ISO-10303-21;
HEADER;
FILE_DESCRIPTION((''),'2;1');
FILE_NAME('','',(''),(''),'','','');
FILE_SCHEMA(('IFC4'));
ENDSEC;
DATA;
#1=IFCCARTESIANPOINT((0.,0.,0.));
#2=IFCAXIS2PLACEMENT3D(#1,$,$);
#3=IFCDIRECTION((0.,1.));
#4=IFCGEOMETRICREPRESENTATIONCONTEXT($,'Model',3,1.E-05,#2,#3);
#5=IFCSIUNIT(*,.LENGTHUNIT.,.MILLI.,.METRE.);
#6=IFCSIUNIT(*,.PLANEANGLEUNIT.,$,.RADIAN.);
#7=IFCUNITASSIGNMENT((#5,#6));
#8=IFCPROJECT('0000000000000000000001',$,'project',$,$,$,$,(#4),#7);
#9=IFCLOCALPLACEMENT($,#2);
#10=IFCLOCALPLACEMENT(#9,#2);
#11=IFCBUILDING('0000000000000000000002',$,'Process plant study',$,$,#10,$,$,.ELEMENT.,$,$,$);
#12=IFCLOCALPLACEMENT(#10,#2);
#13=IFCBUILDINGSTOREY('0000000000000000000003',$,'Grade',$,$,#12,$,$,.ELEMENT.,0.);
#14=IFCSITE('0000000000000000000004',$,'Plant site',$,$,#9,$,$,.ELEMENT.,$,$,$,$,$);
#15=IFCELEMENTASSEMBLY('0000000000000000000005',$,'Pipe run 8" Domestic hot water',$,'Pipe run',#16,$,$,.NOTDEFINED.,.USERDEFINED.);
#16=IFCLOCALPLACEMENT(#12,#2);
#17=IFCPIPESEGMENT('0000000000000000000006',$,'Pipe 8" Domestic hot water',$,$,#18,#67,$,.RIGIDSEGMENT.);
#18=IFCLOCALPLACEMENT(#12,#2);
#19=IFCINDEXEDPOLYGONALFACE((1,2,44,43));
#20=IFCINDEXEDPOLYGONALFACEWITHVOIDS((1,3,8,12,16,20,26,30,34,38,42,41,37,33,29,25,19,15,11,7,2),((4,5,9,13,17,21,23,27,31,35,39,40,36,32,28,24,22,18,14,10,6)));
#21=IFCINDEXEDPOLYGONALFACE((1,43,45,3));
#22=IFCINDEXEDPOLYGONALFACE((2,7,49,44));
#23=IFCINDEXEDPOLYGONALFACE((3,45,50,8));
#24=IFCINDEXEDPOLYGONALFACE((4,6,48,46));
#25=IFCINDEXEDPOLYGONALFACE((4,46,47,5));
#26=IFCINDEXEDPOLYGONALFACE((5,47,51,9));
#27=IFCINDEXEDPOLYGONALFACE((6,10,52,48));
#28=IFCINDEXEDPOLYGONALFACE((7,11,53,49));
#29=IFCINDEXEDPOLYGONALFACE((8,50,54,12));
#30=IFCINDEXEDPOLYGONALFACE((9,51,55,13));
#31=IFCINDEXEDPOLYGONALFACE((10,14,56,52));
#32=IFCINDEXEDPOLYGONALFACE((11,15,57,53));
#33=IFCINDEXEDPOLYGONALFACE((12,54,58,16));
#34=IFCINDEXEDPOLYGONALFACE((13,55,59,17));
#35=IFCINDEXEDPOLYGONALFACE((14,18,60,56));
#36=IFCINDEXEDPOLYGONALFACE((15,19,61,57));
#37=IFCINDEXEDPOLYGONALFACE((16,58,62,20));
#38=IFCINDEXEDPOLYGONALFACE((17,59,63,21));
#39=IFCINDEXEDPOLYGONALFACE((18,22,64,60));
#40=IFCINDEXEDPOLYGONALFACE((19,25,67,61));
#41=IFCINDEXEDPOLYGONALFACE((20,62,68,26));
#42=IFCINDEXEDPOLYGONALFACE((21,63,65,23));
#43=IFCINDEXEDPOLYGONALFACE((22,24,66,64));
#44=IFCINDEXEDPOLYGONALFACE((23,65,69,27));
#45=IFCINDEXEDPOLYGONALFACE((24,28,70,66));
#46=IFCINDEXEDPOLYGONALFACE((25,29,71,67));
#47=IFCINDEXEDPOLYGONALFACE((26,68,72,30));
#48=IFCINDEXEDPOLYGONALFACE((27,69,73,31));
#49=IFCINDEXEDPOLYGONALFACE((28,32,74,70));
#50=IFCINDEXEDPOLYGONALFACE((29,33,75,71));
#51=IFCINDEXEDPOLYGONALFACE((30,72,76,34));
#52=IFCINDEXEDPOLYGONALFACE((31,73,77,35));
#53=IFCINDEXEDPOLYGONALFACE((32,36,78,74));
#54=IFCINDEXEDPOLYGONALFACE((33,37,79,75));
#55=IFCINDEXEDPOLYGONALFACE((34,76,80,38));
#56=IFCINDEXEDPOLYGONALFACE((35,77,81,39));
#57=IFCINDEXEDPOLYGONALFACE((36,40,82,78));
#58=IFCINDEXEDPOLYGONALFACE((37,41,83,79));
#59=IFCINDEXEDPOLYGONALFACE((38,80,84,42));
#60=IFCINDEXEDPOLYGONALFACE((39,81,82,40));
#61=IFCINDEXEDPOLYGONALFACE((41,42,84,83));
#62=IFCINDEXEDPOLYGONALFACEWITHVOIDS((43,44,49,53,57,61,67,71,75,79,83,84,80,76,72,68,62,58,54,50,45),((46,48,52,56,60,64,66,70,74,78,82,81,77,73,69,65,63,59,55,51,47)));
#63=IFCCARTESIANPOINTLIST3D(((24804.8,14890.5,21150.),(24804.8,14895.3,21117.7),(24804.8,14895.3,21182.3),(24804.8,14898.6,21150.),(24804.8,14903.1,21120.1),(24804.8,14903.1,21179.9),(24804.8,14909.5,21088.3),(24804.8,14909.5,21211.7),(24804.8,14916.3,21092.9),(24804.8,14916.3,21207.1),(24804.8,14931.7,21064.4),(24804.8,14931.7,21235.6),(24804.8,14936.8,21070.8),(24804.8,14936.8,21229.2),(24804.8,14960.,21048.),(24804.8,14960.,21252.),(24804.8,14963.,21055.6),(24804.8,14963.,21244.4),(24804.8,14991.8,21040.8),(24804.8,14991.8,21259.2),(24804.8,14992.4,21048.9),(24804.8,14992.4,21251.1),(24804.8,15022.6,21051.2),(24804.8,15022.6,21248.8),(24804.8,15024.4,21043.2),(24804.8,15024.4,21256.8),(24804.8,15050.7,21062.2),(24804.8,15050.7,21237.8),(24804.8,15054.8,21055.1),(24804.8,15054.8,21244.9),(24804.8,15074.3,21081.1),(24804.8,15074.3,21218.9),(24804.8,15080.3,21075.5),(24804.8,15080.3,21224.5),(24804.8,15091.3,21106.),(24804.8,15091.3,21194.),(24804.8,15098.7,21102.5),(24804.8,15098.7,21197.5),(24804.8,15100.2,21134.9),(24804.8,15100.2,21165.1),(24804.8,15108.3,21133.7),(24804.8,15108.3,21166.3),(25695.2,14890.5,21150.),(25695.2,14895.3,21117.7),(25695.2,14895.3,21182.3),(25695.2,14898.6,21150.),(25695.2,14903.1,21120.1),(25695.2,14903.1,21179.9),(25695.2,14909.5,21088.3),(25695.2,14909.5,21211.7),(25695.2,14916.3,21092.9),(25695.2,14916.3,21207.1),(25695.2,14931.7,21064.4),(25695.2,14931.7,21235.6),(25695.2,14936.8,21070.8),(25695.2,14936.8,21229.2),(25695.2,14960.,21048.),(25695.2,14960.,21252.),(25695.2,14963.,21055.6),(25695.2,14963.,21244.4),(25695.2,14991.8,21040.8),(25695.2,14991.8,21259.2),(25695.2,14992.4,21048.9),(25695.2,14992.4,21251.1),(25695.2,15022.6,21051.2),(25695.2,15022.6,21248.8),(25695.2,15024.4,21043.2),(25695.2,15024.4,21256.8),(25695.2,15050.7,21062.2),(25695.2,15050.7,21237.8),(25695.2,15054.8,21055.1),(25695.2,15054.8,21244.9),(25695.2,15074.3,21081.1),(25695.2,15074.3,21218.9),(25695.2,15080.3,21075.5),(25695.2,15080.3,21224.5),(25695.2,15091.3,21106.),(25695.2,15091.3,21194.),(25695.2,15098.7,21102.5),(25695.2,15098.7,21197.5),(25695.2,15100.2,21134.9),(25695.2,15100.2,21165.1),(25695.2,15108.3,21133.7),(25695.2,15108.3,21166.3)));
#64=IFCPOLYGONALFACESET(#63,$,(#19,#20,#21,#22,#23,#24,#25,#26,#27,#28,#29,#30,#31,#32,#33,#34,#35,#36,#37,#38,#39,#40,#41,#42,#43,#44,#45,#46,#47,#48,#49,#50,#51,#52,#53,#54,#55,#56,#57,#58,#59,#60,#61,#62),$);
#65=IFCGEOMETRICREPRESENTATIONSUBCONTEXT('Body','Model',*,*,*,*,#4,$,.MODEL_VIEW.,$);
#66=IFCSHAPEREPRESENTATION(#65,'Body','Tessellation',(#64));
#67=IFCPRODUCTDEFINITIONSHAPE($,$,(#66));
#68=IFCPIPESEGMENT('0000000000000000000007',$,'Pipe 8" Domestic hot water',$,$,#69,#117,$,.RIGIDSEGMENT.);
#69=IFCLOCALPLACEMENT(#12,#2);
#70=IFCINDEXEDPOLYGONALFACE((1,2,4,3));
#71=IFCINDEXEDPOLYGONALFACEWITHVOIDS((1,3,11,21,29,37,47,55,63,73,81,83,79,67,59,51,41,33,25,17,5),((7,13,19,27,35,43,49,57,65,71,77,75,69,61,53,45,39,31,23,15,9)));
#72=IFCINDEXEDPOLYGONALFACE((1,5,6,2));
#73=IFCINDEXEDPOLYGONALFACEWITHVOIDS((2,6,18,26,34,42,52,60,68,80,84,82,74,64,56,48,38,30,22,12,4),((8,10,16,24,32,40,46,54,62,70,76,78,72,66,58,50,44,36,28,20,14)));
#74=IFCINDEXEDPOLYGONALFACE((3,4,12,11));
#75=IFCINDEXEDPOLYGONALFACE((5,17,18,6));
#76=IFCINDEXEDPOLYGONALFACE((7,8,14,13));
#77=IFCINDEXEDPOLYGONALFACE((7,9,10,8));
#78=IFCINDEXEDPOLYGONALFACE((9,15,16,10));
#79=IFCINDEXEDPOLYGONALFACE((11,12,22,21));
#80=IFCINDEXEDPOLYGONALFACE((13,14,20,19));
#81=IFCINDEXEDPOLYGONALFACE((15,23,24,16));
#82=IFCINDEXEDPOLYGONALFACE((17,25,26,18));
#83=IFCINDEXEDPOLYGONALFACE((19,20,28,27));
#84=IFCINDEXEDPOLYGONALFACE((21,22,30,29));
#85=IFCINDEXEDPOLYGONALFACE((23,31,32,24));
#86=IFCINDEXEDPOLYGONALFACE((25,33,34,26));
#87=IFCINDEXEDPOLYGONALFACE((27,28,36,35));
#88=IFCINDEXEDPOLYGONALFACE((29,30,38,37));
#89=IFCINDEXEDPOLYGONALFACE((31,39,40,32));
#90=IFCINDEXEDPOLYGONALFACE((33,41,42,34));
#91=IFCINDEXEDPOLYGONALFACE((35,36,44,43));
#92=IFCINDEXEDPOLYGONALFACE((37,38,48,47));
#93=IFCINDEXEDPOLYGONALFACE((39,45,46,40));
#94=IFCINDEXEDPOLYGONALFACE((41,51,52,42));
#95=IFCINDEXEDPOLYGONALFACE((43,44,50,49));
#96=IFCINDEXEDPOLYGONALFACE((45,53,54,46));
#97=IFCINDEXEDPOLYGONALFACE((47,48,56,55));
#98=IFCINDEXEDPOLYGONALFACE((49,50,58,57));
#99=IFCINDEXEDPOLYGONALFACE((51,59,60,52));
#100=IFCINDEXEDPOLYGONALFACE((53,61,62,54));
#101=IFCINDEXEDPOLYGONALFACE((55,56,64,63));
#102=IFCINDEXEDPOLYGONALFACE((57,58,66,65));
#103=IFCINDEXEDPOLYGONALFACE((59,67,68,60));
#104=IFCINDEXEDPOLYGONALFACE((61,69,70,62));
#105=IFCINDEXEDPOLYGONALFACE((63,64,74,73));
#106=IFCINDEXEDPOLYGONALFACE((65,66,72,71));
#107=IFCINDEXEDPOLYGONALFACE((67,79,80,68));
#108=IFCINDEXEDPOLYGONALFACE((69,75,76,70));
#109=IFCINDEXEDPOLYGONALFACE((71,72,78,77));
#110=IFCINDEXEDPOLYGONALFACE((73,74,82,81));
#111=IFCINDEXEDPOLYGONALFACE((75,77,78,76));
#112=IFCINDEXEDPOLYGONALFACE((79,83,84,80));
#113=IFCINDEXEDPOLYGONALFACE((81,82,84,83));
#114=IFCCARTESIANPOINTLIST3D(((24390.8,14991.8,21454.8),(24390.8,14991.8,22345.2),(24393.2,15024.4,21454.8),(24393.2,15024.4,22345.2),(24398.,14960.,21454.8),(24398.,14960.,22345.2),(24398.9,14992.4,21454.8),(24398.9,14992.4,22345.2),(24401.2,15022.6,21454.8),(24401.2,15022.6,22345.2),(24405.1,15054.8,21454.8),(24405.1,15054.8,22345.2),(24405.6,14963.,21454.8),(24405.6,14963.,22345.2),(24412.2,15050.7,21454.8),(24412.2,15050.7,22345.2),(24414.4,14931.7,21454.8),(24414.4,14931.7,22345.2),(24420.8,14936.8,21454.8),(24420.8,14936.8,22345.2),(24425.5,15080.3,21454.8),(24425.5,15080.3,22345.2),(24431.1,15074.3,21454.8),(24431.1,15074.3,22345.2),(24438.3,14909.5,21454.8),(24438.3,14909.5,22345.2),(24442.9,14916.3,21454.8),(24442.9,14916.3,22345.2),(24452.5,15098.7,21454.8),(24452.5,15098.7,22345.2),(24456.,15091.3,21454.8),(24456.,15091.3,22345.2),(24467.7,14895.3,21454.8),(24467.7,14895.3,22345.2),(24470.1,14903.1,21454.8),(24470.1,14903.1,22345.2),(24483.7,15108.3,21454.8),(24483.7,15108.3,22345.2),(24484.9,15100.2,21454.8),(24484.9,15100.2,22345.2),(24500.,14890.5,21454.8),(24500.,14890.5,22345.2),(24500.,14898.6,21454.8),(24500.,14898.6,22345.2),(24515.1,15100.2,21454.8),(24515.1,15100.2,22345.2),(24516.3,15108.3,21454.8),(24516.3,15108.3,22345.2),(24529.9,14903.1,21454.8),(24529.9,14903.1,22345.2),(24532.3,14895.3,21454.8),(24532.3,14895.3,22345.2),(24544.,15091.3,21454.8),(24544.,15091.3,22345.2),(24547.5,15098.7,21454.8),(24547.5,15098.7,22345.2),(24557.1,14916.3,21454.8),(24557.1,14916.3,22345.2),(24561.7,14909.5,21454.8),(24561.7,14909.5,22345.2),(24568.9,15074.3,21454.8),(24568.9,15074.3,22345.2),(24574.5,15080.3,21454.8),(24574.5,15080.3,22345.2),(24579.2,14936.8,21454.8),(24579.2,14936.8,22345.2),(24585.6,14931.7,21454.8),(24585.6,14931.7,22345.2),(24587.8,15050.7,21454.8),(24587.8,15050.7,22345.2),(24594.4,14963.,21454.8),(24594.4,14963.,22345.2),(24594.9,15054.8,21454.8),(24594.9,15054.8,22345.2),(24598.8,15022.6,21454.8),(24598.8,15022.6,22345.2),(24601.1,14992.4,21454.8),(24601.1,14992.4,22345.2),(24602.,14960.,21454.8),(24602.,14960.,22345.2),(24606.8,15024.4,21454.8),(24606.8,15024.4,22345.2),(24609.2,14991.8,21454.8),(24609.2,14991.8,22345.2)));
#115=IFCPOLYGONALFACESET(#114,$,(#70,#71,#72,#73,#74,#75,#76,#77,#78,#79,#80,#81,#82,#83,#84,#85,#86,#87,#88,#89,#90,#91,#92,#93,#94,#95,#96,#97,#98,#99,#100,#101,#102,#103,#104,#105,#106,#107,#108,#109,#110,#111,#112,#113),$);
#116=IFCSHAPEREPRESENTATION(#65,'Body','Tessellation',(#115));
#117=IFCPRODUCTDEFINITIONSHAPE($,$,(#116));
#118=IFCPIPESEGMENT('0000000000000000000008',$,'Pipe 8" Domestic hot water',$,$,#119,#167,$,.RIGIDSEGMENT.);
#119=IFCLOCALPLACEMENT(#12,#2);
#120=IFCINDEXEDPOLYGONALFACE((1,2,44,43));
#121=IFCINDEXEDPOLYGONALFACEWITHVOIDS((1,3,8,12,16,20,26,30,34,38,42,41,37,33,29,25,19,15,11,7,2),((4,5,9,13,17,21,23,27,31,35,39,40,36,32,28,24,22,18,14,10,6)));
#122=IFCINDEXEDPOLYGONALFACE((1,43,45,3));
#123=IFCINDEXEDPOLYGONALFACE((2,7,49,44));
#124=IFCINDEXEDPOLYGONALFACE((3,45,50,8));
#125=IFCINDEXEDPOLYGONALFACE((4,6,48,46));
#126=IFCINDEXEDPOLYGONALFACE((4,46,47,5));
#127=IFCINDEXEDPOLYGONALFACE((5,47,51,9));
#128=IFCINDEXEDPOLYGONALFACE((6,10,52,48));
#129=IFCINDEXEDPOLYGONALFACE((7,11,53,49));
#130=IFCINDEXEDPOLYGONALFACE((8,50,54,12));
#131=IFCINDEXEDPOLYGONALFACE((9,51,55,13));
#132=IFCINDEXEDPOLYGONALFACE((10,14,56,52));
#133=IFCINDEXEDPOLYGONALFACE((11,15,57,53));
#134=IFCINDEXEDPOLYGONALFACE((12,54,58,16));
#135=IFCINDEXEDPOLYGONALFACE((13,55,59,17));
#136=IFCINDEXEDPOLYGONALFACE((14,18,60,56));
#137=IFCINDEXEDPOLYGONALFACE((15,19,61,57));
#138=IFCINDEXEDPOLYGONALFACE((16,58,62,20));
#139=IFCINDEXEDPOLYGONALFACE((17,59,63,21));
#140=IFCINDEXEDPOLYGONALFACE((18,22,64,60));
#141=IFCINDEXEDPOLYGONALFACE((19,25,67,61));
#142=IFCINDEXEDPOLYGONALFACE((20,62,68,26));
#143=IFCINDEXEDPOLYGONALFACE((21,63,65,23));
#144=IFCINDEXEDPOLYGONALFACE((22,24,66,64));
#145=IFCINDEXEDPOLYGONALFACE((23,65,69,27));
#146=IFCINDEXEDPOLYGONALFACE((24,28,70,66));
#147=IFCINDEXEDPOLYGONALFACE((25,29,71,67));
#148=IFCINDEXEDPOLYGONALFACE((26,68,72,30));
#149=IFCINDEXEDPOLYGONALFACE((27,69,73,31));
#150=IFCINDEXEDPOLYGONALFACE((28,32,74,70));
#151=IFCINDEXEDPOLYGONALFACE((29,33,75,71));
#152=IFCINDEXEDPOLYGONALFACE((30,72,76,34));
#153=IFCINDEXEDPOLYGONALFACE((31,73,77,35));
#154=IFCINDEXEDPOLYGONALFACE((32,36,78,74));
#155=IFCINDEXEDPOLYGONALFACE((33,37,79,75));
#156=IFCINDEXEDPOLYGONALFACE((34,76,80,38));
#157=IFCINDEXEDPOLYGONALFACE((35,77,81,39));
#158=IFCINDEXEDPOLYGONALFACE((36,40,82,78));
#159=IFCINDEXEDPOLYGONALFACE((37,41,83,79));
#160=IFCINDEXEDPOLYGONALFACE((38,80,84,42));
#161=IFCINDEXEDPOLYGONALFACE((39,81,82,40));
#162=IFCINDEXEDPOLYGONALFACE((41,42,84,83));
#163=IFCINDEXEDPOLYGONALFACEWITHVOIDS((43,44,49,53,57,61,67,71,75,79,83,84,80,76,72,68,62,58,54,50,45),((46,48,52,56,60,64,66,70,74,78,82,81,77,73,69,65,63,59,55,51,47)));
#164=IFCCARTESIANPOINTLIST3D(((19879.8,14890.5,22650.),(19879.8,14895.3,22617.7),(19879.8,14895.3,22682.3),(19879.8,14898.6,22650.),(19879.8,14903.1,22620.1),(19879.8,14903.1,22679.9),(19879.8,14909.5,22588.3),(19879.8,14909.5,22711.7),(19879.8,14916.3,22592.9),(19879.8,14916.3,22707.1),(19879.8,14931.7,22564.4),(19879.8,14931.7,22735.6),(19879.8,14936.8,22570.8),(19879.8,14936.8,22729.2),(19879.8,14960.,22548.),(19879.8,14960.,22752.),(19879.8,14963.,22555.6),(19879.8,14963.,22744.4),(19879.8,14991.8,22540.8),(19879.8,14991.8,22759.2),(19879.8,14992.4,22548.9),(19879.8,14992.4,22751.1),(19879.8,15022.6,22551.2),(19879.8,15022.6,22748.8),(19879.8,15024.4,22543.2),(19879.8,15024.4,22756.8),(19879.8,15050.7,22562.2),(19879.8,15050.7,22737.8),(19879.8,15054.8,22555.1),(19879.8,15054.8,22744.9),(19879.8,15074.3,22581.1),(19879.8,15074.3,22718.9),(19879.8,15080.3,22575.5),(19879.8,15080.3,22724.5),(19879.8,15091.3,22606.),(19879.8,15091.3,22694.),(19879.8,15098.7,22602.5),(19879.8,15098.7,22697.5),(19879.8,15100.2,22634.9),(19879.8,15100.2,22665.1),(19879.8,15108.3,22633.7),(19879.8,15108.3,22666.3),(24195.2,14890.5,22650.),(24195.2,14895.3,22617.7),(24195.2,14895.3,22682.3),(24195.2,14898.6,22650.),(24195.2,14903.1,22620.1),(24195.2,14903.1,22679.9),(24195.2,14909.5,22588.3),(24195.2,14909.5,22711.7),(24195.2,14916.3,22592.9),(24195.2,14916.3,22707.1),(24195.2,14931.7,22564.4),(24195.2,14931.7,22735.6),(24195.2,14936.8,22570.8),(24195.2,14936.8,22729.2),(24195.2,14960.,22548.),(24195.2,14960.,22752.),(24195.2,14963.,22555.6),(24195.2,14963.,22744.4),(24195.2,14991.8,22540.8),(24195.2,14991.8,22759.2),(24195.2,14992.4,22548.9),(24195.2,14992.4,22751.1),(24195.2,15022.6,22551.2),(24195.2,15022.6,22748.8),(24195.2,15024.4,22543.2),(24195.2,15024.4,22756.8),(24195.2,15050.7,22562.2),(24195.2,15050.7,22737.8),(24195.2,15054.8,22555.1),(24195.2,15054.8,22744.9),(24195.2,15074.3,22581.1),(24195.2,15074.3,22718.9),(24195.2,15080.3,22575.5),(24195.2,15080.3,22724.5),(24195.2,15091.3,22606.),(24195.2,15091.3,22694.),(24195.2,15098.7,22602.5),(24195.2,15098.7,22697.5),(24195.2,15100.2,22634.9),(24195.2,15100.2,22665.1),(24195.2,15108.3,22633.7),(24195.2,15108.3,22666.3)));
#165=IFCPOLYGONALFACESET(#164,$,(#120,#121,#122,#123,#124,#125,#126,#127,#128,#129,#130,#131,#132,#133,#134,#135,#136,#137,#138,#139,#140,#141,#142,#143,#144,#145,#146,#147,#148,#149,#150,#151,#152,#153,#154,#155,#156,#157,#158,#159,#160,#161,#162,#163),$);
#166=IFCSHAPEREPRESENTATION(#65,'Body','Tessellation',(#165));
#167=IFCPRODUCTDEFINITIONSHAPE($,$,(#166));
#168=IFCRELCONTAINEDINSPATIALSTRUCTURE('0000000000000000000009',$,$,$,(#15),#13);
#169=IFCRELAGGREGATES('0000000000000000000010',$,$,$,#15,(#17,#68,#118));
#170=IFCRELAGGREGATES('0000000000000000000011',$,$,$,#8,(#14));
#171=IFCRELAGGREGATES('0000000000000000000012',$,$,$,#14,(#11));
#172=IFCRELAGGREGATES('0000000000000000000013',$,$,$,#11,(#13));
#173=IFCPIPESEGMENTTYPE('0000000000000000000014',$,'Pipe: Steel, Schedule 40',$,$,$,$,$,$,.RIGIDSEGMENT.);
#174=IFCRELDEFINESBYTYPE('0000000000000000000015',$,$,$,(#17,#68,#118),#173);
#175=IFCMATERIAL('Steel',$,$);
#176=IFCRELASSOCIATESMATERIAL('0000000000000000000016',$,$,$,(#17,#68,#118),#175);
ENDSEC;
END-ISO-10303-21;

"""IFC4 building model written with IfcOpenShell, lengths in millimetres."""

from ifc_helpers import new_model, si_unit, direction, frame, origin, origin_with_axes, origin_2d, place, context, subcontext, project, spatial, hollow_circle, extrude, material, type_object, element, aggregate, save


model = new_model("IFC4")

# Units and contexts
model_context = context("Model", 3, precision=1e-05, world=origin(), true_north=direction((0.0, 1.0)))
body_context = subcontext(model_context, "Body", "Model", "MODEL_VIEW")
ifc_project = project(units=[si_unit("LENGTHUNIT", "METRE", prefix="MILLI"), si_unit("PLANEANGLEUNIT", "RADIAN")], contexts=[model_context])

# Site, building, storey
site_placement = place(None, origin())
site = spatial("IfcSite", under=ifc_project, at=site_placement, Name="Plant site", CompositionType="ELEMENT")
building_placement = place(site_placement, origin())
building = spatial("IfcBuilding", under=site, at=building_placement, Name="Process plant study", CompositionType="ELEMENT")
storey_placement = place(building_placement, origin())
storey = spatial("IfcBuildingStorey", under=building, at=storey_placement, Name="Grade", CompositionType="ELEMENT", Elevation=0.0)

# Element assembly, pipe segments
assembly_1_placement = place(storey_placement, origin_with_axes())
assembly_1 = element("IfcElementAssembly", 1, at=assembly_1_placement, inside=storey, Name="Pipe run 8\" Domestic hot water", ObjectType="Pipe run", AssemblyPlace="NOTDEFINED", PredefinedType="USERDEFINED")
ifc_material = material(Name="Steel")
pipe_segment_type = type_object("IfcPipeSegmentType", Name="Pipe: Steel, Schedule 40", PredefinedType="RIGIDSEGMENT")
pipe_segment_1_placement = place(storey_placement, origin_with_axes())
pipe_segment_1 = element("IfcPipeSegment", 2, at=pipe_segment_1_placement, type_object=pipe_segment_type, material=ifc_material, Name="Pipe 8\" Domestic hot water", PredefinedType="RIGIDSEGMENT", context=body_context, shape_type="SweptSolid", body=[
    extrude(hollow_circle(Radius=109.5, WallThickness=8.2, at=origin_2d()), frame((25695.2, 15000.0, 21150.0), z_axis=(-1.0, 0.0, 0.0), x_axis=(0.0, -1.0, 0.0)), (0.0, 0.0, 1.0), 890.4),
])
pipe_segment_2_placement = place(storey_placement, origin_with_axes())
pipe_segment_2 = element("IfcPipeSegment", 3, at=pipe_segment_2_placement, type_object=pipe_segment_type, material=ifc_material, Name="Pipe 8\" Domestic hot water", PredefinedType="RIGIDSEGMENT", context=body_context, shape_type="SweptSolid", body=[
    extrude(hollow_circle(Radius=109.5, WallThickness=8.2, at=origin_2d()), frame((24500.0, 15000.0, 21454.8), z_axis=(0.0, 0.0, 1.0), x_axis=(0.0, -1.0, 0.0)), (0.0, 0.0, 1.0), 890.4),
])
pipe_segment_3_placement = place(storey_placement, origin_with_axes())
pipe_segment_3 = element("IfcPipeSegment", 4, at=pipe_segment_3_placement, type_object=pipe_segment_type, material=ifc_material, Name="Pipe 8\" Domestic hot water", PredefinedType="RIGIDSEGMENT", context=body_context, shape_type="SweptSolid", body=[
    extrude(hollow_circle(Radius=109.5, WallThickness=8.2, at=origin_2d()), frame((24195.2, 15000.0, 22650.0), z_axis=(-1.0, 0.0, 0.0), x_axis=(0.0, -1.0, 0.0)), (0.0, 0.0, 1.0), 4315.4),
])

aggregate(assembly_1, [pipe_segment_1, pipe_segment_2, pipe_segment_3])

save(model, "model.ifc")
